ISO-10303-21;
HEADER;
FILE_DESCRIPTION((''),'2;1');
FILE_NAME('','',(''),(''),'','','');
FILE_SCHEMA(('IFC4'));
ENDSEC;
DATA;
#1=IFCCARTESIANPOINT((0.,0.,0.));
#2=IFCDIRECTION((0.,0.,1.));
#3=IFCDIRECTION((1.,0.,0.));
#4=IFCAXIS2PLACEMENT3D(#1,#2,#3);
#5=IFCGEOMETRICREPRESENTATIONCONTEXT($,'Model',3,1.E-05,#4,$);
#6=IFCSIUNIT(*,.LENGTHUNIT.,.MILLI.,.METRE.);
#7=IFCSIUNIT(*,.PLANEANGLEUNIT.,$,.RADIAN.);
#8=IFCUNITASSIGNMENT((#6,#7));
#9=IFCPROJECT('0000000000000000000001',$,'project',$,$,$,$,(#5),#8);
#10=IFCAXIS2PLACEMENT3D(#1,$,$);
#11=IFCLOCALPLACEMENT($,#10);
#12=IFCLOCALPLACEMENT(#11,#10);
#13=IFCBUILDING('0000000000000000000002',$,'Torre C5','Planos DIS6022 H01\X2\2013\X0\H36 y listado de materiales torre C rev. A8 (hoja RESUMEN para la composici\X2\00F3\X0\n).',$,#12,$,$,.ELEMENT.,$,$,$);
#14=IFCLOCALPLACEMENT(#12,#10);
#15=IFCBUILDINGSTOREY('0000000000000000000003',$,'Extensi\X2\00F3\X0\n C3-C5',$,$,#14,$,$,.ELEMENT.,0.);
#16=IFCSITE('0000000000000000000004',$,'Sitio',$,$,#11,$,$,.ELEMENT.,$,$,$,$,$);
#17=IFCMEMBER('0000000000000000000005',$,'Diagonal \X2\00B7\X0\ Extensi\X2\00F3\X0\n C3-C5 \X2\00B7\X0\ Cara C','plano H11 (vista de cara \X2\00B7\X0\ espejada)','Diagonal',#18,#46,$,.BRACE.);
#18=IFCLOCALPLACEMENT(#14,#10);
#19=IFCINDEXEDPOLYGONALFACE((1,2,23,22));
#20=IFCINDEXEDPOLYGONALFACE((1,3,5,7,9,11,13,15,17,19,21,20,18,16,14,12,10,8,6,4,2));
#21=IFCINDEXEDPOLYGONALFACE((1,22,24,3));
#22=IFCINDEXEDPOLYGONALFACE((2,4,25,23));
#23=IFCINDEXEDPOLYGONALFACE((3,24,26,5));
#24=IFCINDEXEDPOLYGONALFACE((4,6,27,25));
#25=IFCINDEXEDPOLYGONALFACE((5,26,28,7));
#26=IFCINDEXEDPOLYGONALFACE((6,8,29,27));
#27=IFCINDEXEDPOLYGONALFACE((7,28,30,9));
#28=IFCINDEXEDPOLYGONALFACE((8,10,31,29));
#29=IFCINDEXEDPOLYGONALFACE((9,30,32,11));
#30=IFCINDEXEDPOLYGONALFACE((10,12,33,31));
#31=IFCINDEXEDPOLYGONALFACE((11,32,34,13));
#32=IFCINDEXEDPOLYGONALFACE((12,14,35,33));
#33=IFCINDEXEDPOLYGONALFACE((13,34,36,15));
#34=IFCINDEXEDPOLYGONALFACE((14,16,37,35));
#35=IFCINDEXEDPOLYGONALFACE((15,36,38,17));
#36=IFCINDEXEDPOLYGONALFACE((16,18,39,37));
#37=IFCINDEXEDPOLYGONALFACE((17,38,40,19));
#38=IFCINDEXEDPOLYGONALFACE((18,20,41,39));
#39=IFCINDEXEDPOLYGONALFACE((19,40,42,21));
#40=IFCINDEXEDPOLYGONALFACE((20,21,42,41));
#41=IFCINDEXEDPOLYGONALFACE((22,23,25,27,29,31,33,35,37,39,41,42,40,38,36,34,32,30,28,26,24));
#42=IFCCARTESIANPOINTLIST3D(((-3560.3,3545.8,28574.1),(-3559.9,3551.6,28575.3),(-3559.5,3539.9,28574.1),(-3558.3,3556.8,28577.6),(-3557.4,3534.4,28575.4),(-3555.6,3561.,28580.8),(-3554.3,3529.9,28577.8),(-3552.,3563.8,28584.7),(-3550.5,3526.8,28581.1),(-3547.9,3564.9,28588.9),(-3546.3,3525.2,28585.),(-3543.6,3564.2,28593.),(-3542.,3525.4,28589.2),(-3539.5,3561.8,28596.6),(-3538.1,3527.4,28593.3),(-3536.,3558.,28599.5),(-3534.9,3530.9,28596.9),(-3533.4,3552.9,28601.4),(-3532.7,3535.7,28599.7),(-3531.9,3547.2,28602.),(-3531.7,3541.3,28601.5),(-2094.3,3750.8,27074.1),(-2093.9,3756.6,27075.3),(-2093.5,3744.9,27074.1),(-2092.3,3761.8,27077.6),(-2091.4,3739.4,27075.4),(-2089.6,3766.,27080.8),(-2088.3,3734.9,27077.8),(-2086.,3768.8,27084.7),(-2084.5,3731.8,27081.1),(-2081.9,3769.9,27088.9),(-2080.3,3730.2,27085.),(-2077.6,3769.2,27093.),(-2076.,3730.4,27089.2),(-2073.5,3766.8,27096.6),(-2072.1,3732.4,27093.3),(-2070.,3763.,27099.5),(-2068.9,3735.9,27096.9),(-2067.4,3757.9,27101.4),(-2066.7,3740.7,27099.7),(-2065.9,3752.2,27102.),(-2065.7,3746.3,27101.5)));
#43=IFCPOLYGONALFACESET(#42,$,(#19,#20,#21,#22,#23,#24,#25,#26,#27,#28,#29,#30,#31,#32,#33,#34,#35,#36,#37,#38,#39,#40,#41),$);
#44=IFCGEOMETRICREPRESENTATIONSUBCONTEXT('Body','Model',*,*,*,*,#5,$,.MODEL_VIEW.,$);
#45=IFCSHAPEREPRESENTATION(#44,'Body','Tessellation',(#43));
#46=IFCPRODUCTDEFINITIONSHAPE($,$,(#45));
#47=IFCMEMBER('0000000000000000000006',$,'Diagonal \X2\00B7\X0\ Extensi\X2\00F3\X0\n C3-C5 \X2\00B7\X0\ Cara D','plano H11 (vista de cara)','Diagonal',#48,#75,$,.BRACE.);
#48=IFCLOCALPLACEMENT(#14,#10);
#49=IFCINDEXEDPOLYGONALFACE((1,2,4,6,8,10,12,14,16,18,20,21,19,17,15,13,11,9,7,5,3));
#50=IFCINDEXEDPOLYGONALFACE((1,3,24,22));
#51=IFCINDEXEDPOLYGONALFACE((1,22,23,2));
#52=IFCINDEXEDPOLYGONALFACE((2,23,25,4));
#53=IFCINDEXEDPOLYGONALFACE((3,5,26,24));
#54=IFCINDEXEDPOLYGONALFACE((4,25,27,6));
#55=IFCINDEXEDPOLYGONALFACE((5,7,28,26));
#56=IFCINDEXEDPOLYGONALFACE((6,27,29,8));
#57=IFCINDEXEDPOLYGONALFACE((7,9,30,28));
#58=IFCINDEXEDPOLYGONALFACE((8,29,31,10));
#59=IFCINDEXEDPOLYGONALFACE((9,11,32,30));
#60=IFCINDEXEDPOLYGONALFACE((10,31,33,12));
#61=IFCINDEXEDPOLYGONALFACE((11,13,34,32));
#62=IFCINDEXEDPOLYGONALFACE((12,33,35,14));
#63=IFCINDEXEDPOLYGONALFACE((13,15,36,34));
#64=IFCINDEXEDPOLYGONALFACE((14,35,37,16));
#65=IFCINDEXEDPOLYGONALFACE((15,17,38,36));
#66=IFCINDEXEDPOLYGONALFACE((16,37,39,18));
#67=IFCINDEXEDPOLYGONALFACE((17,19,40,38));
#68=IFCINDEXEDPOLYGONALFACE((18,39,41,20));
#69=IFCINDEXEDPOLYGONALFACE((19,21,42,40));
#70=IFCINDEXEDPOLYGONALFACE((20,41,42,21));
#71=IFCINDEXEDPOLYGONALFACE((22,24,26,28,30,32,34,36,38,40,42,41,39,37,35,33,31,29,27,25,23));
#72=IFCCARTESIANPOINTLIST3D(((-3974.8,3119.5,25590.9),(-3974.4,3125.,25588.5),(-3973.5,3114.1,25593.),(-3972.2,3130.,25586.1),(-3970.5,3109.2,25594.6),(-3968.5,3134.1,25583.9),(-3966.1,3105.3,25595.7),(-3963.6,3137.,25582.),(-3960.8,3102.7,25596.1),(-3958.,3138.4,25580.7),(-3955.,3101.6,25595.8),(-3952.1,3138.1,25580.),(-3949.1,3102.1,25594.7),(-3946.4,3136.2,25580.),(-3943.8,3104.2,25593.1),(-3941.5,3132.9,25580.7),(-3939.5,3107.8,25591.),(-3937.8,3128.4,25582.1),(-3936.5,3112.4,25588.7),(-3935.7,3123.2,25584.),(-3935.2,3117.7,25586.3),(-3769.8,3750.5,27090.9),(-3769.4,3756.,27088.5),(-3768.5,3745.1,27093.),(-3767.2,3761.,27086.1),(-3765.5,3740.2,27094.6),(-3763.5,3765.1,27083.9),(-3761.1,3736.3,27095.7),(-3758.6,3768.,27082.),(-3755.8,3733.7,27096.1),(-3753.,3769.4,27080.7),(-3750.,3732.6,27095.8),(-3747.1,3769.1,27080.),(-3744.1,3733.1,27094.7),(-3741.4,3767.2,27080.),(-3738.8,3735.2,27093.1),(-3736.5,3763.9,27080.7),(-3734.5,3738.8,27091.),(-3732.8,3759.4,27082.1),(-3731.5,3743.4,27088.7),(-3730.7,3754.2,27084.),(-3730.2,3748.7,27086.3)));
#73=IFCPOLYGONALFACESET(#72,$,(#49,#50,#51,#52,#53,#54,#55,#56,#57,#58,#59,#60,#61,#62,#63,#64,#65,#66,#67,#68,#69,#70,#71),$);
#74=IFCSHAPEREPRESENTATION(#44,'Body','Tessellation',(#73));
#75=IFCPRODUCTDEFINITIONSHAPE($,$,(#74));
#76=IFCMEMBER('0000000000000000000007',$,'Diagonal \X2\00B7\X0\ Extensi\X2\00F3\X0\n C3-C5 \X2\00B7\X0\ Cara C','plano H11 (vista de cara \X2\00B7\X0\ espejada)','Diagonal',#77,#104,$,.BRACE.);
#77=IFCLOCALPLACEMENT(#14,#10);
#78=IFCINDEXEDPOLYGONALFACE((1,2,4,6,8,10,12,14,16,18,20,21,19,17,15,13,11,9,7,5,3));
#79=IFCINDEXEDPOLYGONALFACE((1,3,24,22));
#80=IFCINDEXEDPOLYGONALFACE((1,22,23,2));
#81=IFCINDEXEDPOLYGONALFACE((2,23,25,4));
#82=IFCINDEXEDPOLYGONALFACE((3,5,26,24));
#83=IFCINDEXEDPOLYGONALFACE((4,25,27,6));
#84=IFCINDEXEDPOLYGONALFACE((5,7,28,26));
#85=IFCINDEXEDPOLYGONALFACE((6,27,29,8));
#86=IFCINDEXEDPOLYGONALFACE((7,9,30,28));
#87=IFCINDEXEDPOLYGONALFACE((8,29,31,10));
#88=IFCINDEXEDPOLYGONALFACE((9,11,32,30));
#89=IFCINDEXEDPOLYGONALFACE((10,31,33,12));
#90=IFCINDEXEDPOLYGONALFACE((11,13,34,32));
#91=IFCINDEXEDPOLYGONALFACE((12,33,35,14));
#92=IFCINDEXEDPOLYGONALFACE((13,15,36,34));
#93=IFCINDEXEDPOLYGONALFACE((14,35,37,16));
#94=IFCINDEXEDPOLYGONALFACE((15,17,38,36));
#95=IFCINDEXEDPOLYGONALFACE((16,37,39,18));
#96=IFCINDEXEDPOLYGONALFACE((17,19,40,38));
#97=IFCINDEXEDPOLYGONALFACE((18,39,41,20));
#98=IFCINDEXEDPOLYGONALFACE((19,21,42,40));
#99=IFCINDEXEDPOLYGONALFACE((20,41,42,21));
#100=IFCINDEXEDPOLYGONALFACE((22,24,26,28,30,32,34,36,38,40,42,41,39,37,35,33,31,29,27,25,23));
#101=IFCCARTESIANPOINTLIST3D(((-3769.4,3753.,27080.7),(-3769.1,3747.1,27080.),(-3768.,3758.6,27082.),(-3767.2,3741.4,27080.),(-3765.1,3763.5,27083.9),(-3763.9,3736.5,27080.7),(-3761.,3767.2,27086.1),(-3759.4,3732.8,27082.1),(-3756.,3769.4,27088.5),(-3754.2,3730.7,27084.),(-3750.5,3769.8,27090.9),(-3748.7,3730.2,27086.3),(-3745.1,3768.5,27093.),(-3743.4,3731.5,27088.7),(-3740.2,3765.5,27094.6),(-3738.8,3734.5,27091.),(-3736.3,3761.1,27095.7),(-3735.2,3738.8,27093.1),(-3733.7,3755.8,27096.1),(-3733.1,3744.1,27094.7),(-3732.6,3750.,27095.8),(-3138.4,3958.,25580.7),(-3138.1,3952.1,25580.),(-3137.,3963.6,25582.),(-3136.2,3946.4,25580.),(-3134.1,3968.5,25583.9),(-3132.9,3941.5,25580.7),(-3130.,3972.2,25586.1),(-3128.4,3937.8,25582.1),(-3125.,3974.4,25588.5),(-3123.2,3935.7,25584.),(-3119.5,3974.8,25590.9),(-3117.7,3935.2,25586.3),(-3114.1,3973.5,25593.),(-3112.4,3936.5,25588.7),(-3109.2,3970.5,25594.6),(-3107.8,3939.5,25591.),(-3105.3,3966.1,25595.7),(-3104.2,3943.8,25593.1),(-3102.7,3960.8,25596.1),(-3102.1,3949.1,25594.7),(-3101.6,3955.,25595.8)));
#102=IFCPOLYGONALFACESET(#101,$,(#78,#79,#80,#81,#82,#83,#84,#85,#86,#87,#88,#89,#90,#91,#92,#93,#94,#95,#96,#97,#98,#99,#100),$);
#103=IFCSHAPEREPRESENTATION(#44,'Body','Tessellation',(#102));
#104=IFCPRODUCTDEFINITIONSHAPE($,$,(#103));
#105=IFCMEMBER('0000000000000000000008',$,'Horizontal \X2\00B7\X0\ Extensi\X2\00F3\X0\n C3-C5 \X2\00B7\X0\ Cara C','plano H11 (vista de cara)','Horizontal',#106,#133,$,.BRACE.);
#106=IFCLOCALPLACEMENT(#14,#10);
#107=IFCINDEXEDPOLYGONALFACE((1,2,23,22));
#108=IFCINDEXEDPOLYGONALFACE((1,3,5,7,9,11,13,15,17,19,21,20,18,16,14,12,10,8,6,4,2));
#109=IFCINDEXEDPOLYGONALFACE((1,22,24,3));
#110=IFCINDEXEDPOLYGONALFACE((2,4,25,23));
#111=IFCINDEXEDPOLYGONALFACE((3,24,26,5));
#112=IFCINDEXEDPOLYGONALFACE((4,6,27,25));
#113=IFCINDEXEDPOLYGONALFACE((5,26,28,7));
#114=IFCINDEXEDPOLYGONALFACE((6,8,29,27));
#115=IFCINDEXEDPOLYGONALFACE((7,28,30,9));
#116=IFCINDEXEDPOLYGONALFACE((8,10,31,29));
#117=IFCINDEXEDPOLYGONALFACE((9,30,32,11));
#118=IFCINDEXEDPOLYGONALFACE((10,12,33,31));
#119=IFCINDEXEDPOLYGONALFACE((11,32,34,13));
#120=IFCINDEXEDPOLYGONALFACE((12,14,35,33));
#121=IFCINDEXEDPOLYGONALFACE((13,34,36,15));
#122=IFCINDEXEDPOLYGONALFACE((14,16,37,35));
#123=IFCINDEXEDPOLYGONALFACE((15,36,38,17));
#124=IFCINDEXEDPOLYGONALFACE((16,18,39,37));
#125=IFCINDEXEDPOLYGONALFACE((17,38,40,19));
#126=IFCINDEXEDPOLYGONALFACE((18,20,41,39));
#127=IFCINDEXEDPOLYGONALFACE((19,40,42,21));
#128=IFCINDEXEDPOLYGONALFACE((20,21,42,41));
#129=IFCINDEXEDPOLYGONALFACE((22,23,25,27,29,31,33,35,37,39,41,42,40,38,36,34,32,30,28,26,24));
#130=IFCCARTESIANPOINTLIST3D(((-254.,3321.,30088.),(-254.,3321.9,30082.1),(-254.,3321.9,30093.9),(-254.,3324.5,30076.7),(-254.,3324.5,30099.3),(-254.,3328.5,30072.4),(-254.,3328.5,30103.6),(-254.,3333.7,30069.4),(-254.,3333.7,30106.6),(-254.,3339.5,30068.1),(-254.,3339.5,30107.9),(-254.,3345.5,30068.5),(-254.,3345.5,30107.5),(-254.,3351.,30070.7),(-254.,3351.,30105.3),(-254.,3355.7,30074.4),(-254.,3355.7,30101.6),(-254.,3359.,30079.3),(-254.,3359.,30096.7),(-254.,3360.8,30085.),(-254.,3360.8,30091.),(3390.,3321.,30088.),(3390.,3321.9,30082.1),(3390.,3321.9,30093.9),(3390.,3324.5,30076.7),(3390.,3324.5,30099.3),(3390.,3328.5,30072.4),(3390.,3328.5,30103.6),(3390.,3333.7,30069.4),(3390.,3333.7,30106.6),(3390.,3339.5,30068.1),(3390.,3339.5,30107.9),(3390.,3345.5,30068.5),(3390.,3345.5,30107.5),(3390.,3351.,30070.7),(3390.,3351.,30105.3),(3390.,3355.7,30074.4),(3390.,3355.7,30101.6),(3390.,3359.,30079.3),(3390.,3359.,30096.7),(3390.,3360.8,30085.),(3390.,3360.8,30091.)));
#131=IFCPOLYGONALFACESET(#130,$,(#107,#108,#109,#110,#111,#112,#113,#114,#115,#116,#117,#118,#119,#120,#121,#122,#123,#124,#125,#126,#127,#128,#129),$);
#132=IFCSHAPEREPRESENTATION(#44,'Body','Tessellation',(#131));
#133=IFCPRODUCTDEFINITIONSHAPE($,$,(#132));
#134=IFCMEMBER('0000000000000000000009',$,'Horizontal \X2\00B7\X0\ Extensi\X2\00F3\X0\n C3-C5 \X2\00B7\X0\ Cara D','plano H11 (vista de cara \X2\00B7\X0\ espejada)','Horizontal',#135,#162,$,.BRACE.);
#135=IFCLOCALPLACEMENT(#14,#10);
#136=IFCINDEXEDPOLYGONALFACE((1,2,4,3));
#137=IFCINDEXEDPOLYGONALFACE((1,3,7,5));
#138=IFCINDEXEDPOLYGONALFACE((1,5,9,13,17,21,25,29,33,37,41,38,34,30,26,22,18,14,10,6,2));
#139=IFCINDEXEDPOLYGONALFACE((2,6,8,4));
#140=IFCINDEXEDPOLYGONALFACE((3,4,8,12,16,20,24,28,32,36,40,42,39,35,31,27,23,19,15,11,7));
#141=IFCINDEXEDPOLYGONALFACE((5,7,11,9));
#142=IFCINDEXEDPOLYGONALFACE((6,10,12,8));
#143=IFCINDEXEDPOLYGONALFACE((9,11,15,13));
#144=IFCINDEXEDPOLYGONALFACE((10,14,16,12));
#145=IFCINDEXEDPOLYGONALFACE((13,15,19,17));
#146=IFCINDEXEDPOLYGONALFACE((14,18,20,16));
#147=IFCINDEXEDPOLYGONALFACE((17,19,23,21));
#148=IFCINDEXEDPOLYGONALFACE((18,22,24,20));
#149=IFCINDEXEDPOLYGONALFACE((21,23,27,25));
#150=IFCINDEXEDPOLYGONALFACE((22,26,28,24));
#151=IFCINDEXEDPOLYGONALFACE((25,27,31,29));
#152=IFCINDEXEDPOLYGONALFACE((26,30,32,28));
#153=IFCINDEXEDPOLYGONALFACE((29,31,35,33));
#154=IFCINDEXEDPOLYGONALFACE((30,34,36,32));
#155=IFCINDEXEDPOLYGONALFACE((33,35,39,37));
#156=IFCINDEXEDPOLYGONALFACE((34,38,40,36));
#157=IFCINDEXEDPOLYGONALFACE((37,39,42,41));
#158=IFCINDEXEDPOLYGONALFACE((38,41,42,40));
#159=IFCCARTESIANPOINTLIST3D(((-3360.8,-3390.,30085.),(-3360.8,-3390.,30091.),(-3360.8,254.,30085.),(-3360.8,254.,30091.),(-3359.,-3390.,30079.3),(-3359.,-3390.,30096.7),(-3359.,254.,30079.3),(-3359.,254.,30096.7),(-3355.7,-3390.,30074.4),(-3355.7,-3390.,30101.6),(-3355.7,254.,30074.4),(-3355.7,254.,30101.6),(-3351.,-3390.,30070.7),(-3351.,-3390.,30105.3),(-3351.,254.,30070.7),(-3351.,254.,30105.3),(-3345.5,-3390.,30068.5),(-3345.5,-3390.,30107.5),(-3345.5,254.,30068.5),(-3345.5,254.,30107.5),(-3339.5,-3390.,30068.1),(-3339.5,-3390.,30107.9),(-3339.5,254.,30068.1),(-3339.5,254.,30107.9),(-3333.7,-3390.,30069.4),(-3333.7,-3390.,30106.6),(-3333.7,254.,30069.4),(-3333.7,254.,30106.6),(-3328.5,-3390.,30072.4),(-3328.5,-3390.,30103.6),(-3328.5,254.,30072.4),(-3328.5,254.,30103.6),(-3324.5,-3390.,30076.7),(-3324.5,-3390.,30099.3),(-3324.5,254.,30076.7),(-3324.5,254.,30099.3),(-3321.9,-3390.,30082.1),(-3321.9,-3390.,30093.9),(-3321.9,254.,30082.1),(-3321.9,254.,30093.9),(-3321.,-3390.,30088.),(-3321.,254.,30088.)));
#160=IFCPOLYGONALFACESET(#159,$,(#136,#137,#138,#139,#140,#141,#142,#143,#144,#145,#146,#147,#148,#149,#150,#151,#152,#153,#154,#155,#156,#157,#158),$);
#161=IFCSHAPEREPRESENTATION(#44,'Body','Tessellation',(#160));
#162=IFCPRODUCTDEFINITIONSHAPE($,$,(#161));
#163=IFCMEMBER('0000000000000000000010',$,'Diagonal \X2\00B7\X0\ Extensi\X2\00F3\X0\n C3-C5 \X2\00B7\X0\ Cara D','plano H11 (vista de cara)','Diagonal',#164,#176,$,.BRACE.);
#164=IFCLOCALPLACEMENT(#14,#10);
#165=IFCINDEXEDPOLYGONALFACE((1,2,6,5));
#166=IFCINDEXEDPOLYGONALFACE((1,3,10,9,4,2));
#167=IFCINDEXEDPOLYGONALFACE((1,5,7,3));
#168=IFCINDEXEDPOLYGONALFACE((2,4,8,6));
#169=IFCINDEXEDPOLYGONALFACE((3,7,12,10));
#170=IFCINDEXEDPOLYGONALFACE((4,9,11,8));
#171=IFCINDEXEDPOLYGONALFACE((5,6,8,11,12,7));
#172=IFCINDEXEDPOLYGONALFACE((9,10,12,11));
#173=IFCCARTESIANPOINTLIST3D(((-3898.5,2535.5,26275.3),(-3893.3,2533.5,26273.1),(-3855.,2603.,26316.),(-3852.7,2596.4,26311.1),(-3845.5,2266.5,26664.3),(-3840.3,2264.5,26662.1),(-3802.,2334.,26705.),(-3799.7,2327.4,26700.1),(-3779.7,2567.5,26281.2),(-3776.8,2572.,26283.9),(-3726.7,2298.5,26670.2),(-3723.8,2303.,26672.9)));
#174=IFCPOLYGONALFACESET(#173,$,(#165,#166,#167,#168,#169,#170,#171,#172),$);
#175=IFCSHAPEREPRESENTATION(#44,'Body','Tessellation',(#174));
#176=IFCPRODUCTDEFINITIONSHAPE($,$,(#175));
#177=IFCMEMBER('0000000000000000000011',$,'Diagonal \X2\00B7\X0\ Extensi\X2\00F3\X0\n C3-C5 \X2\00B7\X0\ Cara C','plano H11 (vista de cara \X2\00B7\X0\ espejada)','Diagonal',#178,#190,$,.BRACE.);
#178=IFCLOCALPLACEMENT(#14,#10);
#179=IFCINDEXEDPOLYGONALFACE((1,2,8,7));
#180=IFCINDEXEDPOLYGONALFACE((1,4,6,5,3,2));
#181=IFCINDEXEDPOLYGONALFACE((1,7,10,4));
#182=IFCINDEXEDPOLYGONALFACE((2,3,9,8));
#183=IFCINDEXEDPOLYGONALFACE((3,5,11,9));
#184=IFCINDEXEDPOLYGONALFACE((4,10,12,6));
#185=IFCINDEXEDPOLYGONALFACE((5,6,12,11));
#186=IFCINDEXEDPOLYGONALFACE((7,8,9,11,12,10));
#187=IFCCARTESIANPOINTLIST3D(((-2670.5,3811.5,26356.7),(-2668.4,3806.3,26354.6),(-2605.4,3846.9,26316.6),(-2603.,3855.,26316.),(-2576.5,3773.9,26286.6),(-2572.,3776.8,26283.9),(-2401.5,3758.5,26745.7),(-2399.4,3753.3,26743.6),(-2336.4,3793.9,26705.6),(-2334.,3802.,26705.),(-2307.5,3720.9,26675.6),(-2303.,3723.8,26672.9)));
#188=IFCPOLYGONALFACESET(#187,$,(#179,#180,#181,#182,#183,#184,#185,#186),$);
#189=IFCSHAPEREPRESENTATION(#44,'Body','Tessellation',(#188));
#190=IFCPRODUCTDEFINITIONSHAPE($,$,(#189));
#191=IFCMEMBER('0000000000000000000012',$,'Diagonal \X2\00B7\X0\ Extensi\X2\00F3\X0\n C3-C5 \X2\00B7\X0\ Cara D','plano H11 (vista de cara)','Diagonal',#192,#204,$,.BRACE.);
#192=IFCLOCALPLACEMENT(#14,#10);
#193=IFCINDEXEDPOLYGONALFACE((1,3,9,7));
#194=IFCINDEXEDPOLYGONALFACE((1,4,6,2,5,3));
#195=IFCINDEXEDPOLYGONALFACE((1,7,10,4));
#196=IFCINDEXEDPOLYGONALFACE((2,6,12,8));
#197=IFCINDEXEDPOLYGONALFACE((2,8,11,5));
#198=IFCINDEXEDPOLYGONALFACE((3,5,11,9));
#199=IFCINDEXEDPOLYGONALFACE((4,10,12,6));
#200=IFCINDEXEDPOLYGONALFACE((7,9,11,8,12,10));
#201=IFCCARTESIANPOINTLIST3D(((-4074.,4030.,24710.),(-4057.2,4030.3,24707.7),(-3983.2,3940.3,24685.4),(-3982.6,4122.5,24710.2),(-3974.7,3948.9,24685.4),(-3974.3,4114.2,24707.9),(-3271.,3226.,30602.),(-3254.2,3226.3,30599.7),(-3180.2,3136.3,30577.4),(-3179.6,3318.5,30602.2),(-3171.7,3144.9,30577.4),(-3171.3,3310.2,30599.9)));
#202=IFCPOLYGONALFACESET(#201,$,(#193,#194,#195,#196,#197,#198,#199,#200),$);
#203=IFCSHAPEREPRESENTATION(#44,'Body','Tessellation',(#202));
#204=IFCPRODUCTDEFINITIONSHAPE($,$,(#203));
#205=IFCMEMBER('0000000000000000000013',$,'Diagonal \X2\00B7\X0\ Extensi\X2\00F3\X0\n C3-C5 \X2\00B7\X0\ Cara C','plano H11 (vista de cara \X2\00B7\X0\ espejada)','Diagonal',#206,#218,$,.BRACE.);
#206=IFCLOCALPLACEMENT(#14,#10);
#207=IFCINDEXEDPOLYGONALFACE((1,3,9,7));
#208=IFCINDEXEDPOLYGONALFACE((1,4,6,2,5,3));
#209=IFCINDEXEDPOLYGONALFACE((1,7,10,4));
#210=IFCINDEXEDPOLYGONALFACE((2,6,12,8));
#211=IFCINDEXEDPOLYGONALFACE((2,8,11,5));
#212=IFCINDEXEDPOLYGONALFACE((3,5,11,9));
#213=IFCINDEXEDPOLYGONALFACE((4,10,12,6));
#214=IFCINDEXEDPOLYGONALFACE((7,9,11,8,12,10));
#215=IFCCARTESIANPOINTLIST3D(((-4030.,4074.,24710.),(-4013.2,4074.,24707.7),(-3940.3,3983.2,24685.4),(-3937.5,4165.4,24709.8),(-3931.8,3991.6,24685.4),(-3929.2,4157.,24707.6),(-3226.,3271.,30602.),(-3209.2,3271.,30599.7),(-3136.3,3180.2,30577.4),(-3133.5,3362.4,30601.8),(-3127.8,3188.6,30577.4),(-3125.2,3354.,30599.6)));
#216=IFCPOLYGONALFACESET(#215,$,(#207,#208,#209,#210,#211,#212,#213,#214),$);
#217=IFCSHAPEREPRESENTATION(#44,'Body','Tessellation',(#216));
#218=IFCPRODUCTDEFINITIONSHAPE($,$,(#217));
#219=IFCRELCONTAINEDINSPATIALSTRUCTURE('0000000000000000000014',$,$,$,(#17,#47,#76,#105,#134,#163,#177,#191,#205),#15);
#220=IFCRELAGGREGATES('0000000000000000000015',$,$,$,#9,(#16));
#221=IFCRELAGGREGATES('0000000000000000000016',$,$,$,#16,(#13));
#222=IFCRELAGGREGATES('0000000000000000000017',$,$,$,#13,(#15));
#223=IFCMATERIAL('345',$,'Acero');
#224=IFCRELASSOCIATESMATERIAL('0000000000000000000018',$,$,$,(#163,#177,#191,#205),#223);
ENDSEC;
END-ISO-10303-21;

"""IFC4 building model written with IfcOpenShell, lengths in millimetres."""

from ifc_helpers import new_model, si_unit, frame, frame_2d, origin, origin_with_axes, place, context, subcontext, project, spatial, circle, l_section, extrude, material, element, save


model = new_model("IFC4")

# Units and contexts
model_context = context("Model", 3, precision=1e-05, world=origin_with_axes())
body_context = subcontext(model_context, "Body", "Model", "MODEL_VIEW")
ifc_project = project(units=[si_unit("LENGTHUNIT", "METRE", prefix="MILLI"), si_unit("PLANEANGLEUNIT", "RADIAN")], contexts=[model_context])

# Site, building, storey
site_placement = place(None, origin())
site = spatial("IfcSite", under=ifc_project, at=site_placement, Name="Sitio", CompositionType="ELEMENT")
building_placement = place(site_placement, origin())
building = spatial("IfcBuilding", under=site, at=building_placement, Name="Torre C5", Description="Planos DIS6022 H01–H36 y listado de materiales torre C rev. A8 (hoja RESUMEN para la composición).", CompositionType="ELEMENT")
storey_placement = place(building_placement, origin())
storey = spatial("IfcBuildingStorey", under=building, at=storey_placement, Name="Extensión C3-C5", CompositionType="ELEMENT", Elevation=0.0)

# Members
ifc_material_1 = material(Name="345", Category="Acero")
for number, where, z_axis, x_axis, name in (
    (1, (-3546.0, 3545.0, 28588.0), (0.69564, 0.097276, -0.711774), (0.39331, -0.880677, 0.264036), "Diagonal · Extensión C3-C5 · Cara C"),
):
    element("IfcMember", number, at=place(storey_placement, frame(where, z_axis=z_axis, x_axis=x_axis)), inside=storey, Name=name, Description="plano H11 (vista de cara · espejada)", ObjectType="Diagonal", PredefinedType="BRACE", context=body_context, shape_type="SweptSolid", body=[
        extrude(circle(Radius=20.0), None, (0.0, 0.0, 1.0), 2107.4),
    ])
for number, where, z_axis, x_axis, name, description in (
    (2, (-3750.0, 3751.0, 27088.0), (-0.124986, -0.384714, -0.914535), (0.777051, -0.61109, 0.150868), "Diagonal · Extensión C3-C5 · Cara D", "plano H11 (vista de cara)"),
    (3, (-3751.0, 3750.0, 27088.0), (0.384714, 0.124986, -0.914535), (0.61109, -0.777051, 0.150868), "Diagonal · Extensión C3-C5 · Cara C", "plano H11 (vista de cara · espejada)"),
):
    element("IfcMember", number, at=place(storey_placement, frame(where, z_axis=z_axis, x_axis=x_axis)), inside=storey, Name=name, Description=description, ObjectType="Diagonal", PredefinedType="BRACE", context=body_context, shape_type="SweptSolid", body=[
        extrude(circle(Radius=20.0), None, (0.0, 0.0, 1.0), 1640.2),
    ])
for number, where, z_axis, x_axis, name, description in (
    (4, (-254.0, 3341.0, 30088.0), (1.0, 0.0, 0.0), (0.0, -1.0, 0.0), "Horizontal · Extensión C3-C5 · Cara C", "plano H11 (vista de cara)"),
    (5, (-3341.0, 254.0, 30088.0), (0.0, -1.0, 0.0), (1.0, 0.0, 0.0), "Horizontal · Extensión C3-C5 · Cara D", "plano H11 (vista de cara · espejada)"),
):
    element("IfcMember", number, at=place(storey_placement, frame(where, z_axis=z_axis, x_axis=x_axis)), inside=storey, Name=name, Description=description, ObjectType="Horizontal", PredefinedType="BRACE", context=body_context, shape_type="SweptSolid", body=[
        extrude(circle(Radius=20.0), None, (0.0, 0.0, 1.0), 3644.0),
    ])
for number, where, z_axis, x_axis, name, description in (
    (6, (-3802.0, 2334.0, 26705.0), (-0.111365, 0.565232, -0.81738), (0.868367, -0.344616, -0.35662), "Diagonal · Extensión C3-C5 · Cara D", "plano H11 (vista de cara)"),
    (7, (-2334.0, 3802.0, 26705.0), (-0.565232, 0.111365, -0.81738), (0.344616, -0.868367, -0.35662), "Diagonal · Extensión C3-C5 · Cara C", "plano H11 (vista de cara · espejada)"),
):
    element("IfcMember", number, at=place(storey_placement, frame(where, z_axis=z_axis, x_axis=x_axis)), inside=storey, material=ifc_material_1, Name=name, Description=description, ObjectType="Diagonal", PredefinedType="BRACE", context=body_context, shape_type="SweptSolid", body=[
        extrude(l_section(Depth=90.0, Width=90.0, Thickness=6.0, at=frame_2d((45.0, 45.0))), None, (0.0, 0.0, 1.0), 475.9),
    ])
for number, where, z_axis, x_axis, name, description in (
    (8, (-4074.0, 4030.0, 24710.0), (0.133821, -0.133987, 0.981906), (0.698705, -0.689893, -0.189364), "Diagonal · Extensión C3-C5 · Cara D", "plano H11 (vista de cara)"),
    (9, (-4030.0, 4074.0, 24710.0), (0.133987, -0.133821, 0.981906), (0.689893, -0.698705, -0.189364), "Diagonal · Extensión C3-C5 · Cara C", "plano H11 (vista de cara · espejada)"),
):
    element("IfcMember", number, at=place(storey_placement, frame(where, z_axis=z_axis, x_axis=x_axis)), inside=storey, material=ifc_material_1, Name=name, Description=description, ObjectType="Diagonal", PredefinedType="BRACE", context=body_context, shape_type="SweptSolid", body=[
        extrude(l_section(Depth=130.0, Width=130.0, Thickness=12.0, at=frame_2d((65.0, 65.0))), None, (0.0, 0.0, 1.0), 6000.6),
    ])

save(model, "model.ifc")
